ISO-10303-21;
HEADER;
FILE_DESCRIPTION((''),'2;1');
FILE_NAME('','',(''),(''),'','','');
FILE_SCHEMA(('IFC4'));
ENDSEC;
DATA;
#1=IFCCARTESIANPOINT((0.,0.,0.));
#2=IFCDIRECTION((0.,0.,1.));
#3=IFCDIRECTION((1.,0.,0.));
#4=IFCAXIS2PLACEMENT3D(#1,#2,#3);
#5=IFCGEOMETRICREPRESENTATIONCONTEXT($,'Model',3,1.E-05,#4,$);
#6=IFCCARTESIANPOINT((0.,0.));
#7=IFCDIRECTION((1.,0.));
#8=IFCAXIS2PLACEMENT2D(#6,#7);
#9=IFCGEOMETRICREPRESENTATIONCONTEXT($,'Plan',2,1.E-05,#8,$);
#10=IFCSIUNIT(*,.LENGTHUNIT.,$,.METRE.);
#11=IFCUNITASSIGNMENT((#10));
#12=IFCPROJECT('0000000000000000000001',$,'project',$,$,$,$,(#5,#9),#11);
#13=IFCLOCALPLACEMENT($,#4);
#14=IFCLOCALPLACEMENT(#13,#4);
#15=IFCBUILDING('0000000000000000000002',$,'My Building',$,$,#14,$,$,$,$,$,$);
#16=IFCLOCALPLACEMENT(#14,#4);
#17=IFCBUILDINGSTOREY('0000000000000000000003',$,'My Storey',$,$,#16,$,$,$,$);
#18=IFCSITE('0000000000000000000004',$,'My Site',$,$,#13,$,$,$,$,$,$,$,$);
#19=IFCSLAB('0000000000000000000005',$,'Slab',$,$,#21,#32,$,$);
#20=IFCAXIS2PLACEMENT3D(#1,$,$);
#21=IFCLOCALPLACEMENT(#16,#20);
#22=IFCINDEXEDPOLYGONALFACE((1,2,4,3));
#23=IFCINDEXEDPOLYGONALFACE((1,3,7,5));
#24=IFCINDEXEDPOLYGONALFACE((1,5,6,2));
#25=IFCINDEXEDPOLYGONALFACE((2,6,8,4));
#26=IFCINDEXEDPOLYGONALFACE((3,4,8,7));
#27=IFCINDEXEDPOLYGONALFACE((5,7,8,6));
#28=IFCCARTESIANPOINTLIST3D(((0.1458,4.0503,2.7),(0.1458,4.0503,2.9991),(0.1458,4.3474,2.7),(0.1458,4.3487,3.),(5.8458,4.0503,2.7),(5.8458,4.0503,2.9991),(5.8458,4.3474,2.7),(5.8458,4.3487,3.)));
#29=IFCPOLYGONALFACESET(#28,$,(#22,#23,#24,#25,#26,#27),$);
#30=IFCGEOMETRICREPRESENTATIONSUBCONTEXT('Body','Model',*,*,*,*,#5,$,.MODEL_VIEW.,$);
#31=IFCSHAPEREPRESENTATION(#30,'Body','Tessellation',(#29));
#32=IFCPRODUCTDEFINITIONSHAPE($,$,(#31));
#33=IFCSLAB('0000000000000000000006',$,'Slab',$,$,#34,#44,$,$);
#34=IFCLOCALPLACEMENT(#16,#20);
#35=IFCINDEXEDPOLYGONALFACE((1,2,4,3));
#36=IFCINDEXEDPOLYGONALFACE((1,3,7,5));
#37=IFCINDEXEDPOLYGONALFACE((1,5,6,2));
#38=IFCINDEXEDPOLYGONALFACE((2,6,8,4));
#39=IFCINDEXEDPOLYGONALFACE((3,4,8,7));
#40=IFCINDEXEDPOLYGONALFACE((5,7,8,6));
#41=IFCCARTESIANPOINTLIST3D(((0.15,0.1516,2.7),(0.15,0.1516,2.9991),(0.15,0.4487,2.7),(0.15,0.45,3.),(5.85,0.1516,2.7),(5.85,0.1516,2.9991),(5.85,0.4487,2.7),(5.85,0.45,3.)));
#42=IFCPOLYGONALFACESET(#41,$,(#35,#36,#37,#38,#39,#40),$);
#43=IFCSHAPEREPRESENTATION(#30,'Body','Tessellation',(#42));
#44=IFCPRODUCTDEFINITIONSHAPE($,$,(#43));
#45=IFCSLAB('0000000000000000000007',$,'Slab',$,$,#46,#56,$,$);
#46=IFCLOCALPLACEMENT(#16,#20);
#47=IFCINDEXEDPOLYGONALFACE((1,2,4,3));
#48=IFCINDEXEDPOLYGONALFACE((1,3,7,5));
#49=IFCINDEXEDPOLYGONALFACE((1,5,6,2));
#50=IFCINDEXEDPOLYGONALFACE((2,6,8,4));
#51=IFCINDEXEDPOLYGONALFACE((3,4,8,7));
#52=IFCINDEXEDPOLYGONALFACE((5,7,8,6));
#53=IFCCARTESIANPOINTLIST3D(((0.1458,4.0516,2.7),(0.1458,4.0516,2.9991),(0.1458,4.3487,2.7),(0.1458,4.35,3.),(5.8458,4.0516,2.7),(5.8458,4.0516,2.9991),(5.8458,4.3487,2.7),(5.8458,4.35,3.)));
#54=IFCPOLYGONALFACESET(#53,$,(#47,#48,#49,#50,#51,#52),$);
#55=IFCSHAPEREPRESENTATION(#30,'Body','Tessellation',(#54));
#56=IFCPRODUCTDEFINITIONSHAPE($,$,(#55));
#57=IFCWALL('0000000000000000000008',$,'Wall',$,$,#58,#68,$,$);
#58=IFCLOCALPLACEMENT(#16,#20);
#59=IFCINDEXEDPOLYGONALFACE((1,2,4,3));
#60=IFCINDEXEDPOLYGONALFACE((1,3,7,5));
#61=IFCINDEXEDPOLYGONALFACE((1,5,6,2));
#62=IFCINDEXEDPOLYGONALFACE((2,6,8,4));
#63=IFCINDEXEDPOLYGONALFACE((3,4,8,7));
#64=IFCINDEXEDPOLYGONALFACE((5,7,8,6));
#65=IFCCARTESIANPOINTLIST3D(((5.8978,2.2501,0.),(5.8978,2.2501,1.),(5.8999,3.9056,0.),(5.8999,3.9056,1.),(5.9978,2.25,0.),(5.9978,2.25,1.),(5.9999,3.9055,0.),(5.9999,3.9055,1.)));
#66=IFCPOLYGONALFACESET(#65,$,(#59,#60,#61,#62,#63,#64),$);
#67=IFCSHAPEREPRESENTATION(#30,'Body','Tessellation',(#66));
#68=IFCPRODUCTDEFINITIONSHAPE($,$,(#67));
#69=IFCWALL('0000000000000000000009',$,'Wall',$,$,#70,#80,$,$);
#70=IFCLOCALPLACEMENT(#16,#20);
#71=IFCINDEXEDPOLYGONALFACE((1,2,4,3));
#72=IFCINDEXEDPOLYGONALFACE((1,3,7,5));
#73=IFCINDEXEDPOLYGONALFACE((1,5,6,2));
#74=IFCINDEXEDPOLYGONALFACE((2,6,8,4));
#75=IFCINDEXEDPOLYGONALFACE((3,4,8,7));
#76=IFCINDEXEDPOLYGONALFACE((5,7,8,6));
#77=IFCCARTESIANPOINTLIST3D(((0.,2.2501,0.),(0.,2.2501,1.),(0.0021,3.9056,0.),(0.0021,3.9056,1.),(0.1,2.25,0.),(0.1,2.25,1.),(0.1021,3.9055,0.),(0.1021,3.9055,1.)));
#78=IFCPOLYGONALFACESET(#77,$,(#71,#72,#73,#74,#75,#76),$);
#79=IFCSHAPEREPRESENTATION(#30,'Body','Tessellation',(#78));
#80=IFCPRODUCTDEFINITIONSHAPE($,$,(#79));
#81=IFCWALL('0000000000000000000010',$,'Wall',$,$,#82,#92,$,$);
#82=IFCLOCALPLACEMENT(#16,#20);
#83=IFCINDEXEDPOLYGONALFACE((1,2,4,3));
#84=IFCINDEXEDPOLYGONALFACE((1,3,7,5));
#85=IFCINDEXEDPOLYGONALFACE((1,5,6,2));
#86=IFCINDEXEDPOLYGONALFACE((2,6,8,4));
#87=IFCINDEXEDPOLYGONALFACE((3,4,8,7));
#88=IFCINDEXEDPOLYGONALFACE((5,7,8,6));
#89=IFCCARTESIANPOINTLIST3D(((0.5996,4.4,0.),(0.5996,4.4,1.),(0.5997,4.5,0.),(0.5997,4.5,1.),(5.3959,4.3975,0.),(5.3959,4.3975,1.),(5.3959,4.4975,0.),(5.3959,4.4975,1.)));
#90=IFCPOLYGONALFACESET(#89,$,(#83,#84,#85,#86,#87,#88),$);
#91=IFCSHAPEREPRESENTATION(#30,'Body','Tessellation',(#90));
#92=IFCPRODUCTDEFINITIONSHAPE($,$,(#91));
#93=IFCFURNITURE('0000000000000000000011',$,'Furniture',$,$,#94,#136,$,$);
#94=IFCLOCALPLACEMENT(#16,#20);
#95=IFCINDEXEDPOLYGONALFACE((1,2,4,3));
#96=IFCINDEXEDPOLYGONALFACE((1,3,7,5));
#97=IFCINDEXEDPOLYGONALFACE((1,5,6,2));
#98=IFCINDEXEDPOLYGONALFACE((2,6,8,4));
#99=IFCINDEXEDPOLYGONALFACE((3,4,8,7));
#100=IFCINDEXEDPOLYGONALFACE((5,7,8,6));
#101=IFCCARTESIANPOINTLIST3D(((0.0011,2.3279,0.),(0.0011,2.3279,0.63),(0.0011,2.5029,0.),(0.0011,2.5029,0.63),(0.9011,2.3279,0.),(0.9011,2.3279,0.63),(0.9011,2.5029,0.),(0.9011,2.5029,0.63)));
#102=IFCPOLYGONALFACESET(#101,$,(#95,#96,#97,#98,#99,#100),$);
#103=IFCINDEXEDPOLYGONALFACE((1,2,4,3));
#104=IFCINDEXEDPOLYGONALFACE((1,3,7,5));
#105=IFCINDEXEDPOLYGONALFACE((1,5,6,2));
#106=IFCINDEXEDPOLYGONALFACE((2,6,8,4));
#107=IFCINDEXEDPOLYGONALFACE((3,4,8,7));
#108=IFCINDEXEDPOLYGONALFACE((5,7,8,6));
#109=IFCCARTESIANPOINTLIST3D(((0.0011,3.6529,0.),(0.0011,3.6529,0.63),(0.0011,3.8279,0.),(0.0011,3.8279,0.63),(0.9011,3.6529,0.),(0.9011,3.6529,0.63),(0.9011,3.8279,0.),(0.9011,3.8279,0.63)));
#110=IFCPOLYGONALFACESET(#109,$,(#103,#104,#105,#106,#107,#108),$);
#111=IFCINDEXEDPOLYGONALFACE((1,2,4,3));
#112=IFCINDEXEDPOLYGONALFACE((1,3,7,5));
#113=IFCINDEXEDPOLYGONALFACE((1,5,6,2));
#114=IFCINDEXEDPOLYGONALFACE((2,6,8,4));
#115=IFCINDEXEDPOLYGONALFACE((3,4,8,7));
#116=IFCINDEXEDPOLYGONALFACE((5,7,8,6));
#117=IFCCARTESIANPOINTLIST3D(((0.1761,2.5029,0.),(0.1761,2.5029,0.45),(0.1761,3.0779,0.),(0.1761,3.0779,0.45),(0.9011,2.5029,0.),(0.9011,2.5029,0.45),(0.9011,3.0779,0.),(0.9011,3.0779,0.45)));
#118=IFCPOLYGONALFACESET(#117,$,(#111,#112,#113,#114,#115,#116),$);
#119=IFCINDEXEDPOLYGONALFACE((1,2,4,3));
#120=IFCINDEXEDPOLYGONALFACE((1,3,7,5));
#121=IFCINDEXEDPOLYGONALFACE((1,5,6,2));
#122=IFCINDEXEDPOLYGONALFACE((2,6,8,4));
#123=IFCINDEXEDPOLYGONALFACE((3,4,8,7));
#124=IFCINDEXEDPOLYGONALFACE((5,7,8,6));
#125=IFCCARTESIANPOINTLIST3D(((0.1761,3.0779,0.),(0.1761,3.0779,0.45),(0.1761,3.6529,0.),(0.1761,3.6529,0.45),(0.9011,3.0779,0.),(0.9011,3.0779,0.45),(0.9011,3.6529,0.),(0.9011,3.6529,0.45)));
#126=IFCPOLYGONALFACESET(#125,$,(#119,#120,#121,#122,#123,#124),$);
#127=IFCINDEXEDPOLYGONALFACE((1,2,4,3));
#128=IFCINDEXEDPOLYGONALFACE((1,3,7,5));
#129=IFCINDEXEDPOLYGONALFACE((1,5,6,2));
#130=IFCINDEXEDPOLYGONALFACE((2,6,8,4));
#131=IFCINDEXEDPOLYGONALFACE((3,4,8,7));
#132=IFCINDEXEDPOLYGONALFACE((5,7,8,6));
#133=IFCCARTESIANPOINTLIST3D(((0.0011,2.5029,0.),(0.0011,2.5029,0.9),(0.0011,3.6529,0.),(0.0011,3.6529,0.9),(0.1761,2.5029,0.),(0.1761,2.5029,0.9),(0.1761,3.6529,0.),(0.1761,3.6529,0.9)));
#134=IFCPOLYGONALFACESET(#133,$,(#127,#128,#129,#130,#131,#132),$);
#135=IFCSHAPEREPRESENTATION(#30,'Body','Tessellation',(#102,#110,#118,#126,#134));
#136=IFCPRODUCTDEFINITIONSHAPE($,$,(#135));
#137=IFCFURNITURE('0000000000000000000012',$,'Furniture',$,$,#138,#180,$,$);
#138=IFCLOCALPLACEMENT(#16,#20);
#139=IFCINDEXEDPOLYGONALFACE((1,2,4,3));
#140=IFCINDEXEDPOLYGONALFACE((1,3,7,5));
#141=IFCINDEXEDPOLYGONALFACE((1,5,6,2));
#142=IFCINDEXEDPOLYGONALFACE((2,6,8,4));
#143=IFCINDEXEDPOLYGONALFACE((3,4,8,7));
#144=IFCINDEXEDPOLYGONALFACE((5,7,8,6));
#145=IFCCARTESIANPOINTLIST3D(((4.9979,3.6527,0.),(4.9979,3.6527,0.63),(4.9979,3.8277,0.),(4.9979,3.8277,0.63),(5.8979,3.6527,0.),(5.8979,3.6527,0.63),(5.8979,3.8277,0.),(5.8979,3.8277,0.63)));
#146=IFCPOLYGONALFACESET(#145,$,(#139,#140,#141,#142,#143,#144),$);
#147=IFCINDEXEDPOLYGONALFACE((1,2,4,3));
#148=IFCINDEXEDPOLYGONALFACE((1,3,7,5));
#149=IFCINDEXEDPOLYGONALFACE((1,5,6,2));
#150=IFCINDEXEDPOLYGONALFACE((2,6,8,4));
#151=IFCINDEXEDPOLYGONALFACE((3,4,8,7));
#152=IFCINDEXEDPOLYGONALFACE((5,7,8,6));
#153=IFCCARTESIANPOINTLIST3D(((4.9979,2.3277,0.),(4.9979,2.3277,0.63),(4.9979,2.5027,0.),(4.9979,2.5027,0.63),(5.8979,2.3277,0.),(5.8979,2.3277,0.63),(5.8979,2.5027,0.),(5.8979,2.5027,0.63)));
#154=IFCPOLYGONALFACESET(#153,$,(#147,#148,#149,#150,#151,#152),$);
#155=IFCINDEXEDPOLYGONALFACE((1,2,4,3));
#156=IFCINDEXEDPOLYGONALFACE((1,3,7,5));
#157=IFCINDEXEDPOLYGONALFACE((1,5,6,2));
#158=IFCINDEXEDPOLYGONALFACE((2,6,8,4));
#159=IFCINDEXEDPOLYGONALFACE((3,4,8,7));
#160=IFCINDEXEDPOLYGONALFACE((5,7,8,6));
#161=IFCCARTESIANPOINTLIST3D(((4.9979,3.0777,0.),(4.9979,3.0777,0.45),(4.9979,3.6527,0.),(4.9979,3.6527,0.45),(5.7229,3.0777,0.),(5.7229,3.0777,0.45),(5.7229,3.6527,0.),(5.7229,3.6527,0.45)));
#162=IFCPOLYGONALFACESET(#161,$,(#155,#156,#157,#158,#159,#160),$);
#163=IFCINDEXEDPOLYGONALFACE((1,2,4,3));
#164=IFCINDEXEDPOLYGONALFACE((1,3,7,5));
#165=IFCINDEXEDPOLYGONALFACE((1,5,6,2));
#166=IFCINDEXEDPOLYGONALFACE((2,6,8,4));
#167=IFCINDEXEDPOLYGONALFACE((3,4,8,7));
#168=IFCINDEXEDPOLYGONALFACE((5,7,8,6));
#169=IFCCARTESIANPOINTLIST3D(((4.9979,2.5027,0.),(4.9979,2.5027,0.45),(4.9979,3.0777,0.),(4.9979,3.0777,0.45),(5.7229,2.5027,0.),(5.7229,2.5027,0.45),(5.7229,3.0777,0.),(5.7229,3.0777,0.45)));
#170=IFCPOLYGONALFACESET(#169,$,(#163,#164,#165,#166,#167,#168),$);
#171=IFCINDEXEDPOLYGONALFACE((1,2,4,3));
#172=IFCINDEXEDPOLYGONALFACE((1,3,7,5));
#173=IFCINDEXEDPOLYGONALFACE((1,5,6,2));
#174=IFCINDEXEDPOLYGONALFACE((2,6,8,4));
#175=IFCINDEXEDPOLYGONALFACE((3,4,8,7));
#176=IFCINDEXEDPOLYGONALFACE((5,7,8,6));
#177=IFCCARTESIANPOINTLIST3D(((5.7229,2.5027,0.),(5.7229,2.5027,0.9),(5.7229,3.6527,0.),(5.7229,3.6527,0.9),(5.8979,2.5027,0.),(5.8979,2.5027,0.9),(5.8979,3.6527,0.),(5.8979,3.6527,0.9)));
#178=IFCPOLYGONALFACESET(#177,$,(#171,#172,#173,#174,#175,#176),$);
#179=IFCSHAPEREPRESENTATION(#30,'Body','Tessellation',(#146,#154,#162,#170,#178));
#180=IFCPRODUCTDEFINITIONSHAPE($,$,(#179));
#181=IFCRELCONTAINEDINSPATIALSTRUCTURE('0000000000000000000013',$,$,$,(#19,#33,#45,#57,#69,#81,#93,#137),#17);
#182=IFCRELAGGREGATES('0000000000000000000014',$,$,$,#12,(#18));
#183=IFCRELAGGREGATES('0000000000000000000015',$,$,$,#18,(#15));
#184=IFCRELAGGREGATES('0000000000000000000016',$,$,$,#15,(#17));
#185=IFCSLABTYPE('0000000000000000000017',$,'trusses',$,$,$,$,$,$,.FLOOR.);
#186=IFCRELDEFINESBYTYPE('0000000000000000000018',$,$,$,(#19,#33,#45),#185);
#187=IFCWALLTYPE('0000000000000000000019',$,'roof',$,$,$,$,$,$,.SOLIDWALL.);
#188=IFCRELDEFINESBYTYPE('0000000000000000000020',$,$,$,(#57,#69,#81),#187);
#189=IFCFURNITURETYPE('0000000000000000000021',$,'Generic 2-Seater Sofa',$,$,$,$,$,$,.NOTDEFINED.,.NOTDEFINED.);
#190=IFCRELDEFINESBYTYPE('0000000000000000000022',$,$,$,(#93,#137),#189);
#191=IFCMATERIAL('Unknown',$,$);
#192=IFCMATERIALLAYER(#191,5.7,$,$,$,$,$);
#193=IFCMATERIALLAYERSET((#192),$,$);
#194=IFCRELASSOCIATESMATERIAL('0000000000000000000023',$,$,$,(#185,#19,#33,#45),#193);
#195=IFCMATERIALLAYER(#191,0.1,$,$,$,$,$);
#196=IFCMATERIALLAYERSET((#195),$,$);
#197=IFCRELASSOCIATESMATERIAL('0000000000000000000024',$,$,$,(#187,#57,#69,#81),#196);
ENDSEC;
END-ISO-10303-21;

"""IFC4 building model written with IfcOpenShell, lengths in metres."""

from ifc_helpers import new_model, entity, si_unit, frame, origin_with_axes, origin_2d_with_axis, place, context, subcontext, project, spatial, line, indexed_curve, outline, extrude, shape, source, transform, mapped, material, layer, layer_set, layer_usage, type_object, type_shapes, element, save


model = new_model("IFC4")

# Units and contexts
model_context = context("Model", 3, precision=1e-05, world=origin_with_axes())
plan_context = context("Plan", 2, precision=1e-05, world=origin_2d_with_axis())
body_context_1 = subcontext(model_context, "Body", "Model", "MODEL_VIEW")
body_context_2 = subcontext(plan_context, "Body", "Plan", "PLAN_VIEW")
ifc_project = project(units=[si_unit("LENGTHUNIT", "METRE")], contexts=[model_context, plan_context])

# Site, building, storey
site_placement = place(None, origin_with_axes())
site = spatial("IfcSite", under=ifc_project, at=site_placement, Name="My Site")
building_placement = place(site_placement, origin_with_axes())
building = spatial("IfcBuilding", under=site, at=building_placement, Name="My Building")
storey_placement = place(building_placement, origin_with_axes())
storey = spatial("IfcBuildingStorey", under=building, at=storey_placement, Name="My Storey")

# Slabs
ifc_material = material(Name="Unknown")
ifc_layer_1 = layer(ifc_material, 5.7)
ifc_layer_set_1 = layer_set([ifc_layer_1])
ifc_layer_usage_1 = layer_usage(ifc_layer_set_1, "AXIS3", "POSITIVE", -1.0)
slab_type_1 = type_object("IfcSlabType", Name="trusses", PredefinedType="FLOOR", material=ifc_layer_set_1)
slab_1_placement = place(storey_placement, frame((4.8458, 4.3474, 2.7), z_axis=(-1.0, 0.0, 0.0), x_axis=(0.0, 0.0, 1.0)))
element("IfcSlab", 1, at=slab_1_placement, inside=storey, type_object=slab_type_1, material=ifc_layer_usage_1, Name="Slab", context=body_context_1, shape_type="SweptSolid", body=[
    extrude(outline(indexed_curve([(0.0, 0.0), (0.0, -0.2971), (0.2991, -0.2971), (0.3, 0.0013), (0.0, 0.0)])), frame((0.0, 0.0, -1.0), z_axis=(0.0, 0.0, 1.0), x_axis=(1.0, 0.0, 0.0)), (0.0, 0.0, 1.0), 5.7),
])
ifc_layer_usage_2 = layer_usage(ifc_layer_set_1, "AXIS3", "POSITIVE", -1.0)
slab_2_placement = place(storey_placement, frame((4.85, 0.4487, 2.7), z_axis=(-1.0, 0.0, 0.0), x_axis=(0.0, 0.0, 1.0)))
element("IfcSlab", 2, at=slab_2_placement, inside=storey, type_object=slab_type_1, material=ifc_layer_usage_2, Name="Slab", context=body_context_1, shape_type="SweptSolid", body=[
    extrude(outline(indexed_curve([(0.0, 0.0), (0.0, -0.2971), (0.2991, -0.2971), (0.3, 0.0013), (0.0, 0.0)])), frame((0.0, 0.0, -1.0), z_axis=(0.0, 0.0, 1.0), x_axis=(1.0, 0.0, 0.0)), (0.0, 0.0, 1.0), 5.7),
])
ifc_layer_usage_3 = layer_usage(ifc_layer_set_1, "AXIS3", "POSITIVE", -1.0)
slab_3_placement = place(storey_placement, frame((4.8458, 4.3487, 2.7), z_axis=(-1.0, 0.0, 0.0), x_axis=(0.0, 0.0, 1.0)))
element("IfcSlab", 3, at=slab_3_placement, inside=storey, type_object=slab_type_1, material=ifc_layer_usage_3, Name="Slab", context=body_context_1, shape_type="SweptSolid", body=[
    extrude(outline(indexed_curve([(0.0, 0.0), (0.0, -0.2971), (0.2991, -0.2971), (0.3, 0.0013), (0.0, 0.0)])), frame((0.0, 0.0, -1.0), z_axis=(0.0, 0.0, 1.0), x_axis=(1.0, 0.0, 0.0)), (0.0, 0.0, 1.0), 5.7),
])

# Walls
ifc_layer_2 = layer(ifc_material, 0.1)
ifc_layer_set_2 = layer_set([ifc_layer_2])
ifc_layer_usage_4 = layer_usage(ifc_layer_set_2, "AXIS2", "POSITIVE", 0.0)
wall_type = type_object("IfcWallType", Name="roof", PredefinedType="SOLIDWALL", material=ifc_layer_set_2)
wall_1_placement = place(storey_placement, frame((5.9978, 2.25, 0.0), z_axis=(0.0, 0.0, 1.0), x_axis=(0.001288, 0.999999, 0.0)))
element("IfcWall", 4, at=wall_1_placement, inside=storey, type_object=wall_type, material=ifc_layer_usage_4, Name="Wall", context=body_context_1, shape_type="SweptSolid", body=[
    extrude(outline(indexed_curve([(0.0, 0.0), (0.0, 0.1), (1.6555, 0.1), (1.6555, 0.0)], segments=[line(1, 2, 3, 4, 1)])), origin_with_axes(), (0.0, 0.0, 1.0), 1.0),
])
ifc_layer_usage_5 = layer_usage(ifc_layer_set_2, "AXIS2", "POSITIVE", 0.0)
wall_2_placement = place(storey_placement, frame((0.1, 2.25, 0.0), z_axis=(0.0, 0.0, 1.0), x_axis=(0.001288, 0.999999, 0.0)))
element("IfcWall", 5, at=wall_2_placement, inside=storey, type_object=wall_type, material=ifc_layer_usage_5, Name="Wall", context=body_context_1, shape_type="SweptSolid", body=[
    extrude(outline(indexed_curve([(0.0, 0.0), (0.0, 0.1), (1.6555, 0.1), (1.6555, 0.0)], segments=[line(1, 2, 3, 4, 1)])), origin_with_axes(), (0.0, 0.0, 1.0), 1.0),
])
ifc_layer_usage_6 = layer_usage(ifc_layer_set_2, "AXIS2", "POSITIVE", 0.0)
wall_3_placement = place(storey_placement, frame((5.3959, 4.4975, 0.0), z_axis=(0.0, 0.0, 1.0), x_axis=(-1.0, 0.000525, 0.0)))
element("IfcWall", 6, at=wall_3_placement, inside=storey, type_object=wall_type, material=ifc_layer_usage_6, Name="Wall", context=body_context_1, shape_type="SweptSolid", body=[
    extrude(outline(indexed_curve([(0.0, 0.0), (0.0, 0.1), (4.7962, 0.1), (4.7962, 0.0)], segments=[line(1, 2, 3, 4, 1)])), origin_with_axes(), (0.0, 0.0, 1.0), 1.0),
])

# Furniture
furniture_type_1 = type_object("IfcFurnitureType", Name="Generic 2-Seater Sofa", AssemblyPlace="NOTDEFINED", PredefinedType="NOTDEFINED")
shared_shape_1 = source(origin_with_axes(), body_context_1, "Body", "SweptSolid", [
    extrude(outline(indexed_curve([(0.0, 0.0), (0.175, 0.0), (0.175, 0.9), (0.0, 0.9)], segments=[line(1, 2, 3, 4, 1)])), frame((-0.75, -0.9, 0.0), z_axis=(0.0, 0.0, 1.0), x_axis=(1.0, 0.0, 0.0)), (0.0, 0.0, 1.0), 0.63),
    extrude(outline(indexed_curve([(0.0, 0.0), (0.175, 0.0), (0.175, 0.9), (0.0, 0.9)], segments=[line(1, 2, 3, 4, 1)])), frame((0.575, -0.9, 0.0), z_axis=(0.0, 0.0, 1.0), x_axis=(1.0, 0.0, 0.0)), (0.0, 0.0, 1.0), 0.63),
    extrude(outline(indexed_curve([(0.175, 0.0), (0.75, 0.0), (0.75, 0.725), (0.175, 0.725)], segments=[line(1, 2, 3, 4, 1)])), frame((-0.75, -0.9, 0.0), z_axis=(0.0, 0.0, 1.0), x_axis=(1.0, 0.0, 0.0)), (0.0, 0.0, 1.0), 0.45),
    extrude(outline(indexed_curve([(0.75, 0.0), (1.325, 0.0), (1.325, 0.725), (0.75, 0.725)], segments=[line(1, 2, 3, 4, 1)])), frame((-0.75, -0.9, 0.0), z_axis=(0.0, 0.0, 1.0), x_axis=(1.0, 0.0, 0.0)), (0.0, 0.0, 1.0), 0.45),
    extrude(outline(indexed_curve([(0.175, 0.725), (1.325, 0.725), (1.325, 0.9), (0.175, 0.9)], segments=[line(1, 2, 3, 4, 1)])), frame((-0.75, -0.9, 0.0), z_axis=(0.0, 0.0, 1.0), x_axis=(1.0, 0.0, 0.0)), (0.0, 0.0, 1.0), 0.9),
])
shared_shape_2 = source(origin_with_axes(), body_context_2, "Body", "Curve2D", [
    entity("IfcIndexedPolyCurve", entity("IfcCartesianPointList2D", [[-0.75, -0.9], [-0.575, -0.9], [-0.575, 0.0], [-0.75, 0.0]]), [entity("IfcLineIndex", [1, 2, 3, 4, 1])]),
    entity("IfcIndexedPolyCurve", entity("IfcCartesianPointList2D", [[0.575, -0.9], [0.75, -0.9], [0.75, 0.0], [0.575, 0.0]]), [entity("IfcLineIndex", [1, 2, 3, 4, 1])]),
    entity("IfcIndexedPolyCurve", entity("IfcCartesianPointList2D", [[-0.575, -0.9], [0.0, -0.9], [0.0, -0.175], [-0.575, -0.175]]), [entity("IfcLineIndex", [1, 2, 3, 4, 1])]),
    entity("IfcIndexedPolyCurve", entity("IfcCartesianPointList2D", [[0.0, -0.9], [0.575, -0.9], [0.575, -0.175], [0.0, -0.175]]), [entity("IfcLineIndex", [1, 2, 3, 4, 1])]),
    entity("IfcIndexedPolyCurve", entity("IfcCartesianPointList2D", [[-0.575, -0.175], [0.575, -0.175], [0.575, 0.0], [-0.575, 0.0]]), [entity("IfcLineIndex", [1, 2, 3, 4, 1])]),
])
type_shapes(furniture_type_1, [shared_shape_1, shared_shape_2])
for number, where, z_axis, x_axis, name in (
    (7, (0.0011, 3.0779, 0.0), (0.0, 0.0, 1.0), (0.0, 1.0, 0.0), "Furniture"),
    (8, (5.8979, 3.0777, 0.0), (0.0, 0.0, 1.0), (0.0, -1.0, 0.0), "Furniture"),
):
    element("IfcFurniture", number, at=place(storey_placement, frame(where, z_axis=z_axis, x_axis=x_axis)), inside=storey, type_object=furniture_type_1, Name=name, shapes=[
        shape(body_context_1, "Body", "MappedRepresentation", [mapped(shared_shape_1, transform((0.0, 0.0, 0.0), x_axis=(1.0, 0.0, 0.0), y_axis=(0.0, 1.0, 0.0), z_axis=(0.0, 0.0, 1.0), scale=1.0))]),
        shape(body_context_2, "Body", "MappedRepresentation", [mapped(shared_shape_2, transform((0.0, 0.0, 0.0), x_axis=(1.0, 0.0, 0.0), y_axis=(0.0, 1.0, 0.0), z_axis=(0.0, 0.0, 1.0), scale=1.0))]),
    ])

save(model, "model.ifc")
